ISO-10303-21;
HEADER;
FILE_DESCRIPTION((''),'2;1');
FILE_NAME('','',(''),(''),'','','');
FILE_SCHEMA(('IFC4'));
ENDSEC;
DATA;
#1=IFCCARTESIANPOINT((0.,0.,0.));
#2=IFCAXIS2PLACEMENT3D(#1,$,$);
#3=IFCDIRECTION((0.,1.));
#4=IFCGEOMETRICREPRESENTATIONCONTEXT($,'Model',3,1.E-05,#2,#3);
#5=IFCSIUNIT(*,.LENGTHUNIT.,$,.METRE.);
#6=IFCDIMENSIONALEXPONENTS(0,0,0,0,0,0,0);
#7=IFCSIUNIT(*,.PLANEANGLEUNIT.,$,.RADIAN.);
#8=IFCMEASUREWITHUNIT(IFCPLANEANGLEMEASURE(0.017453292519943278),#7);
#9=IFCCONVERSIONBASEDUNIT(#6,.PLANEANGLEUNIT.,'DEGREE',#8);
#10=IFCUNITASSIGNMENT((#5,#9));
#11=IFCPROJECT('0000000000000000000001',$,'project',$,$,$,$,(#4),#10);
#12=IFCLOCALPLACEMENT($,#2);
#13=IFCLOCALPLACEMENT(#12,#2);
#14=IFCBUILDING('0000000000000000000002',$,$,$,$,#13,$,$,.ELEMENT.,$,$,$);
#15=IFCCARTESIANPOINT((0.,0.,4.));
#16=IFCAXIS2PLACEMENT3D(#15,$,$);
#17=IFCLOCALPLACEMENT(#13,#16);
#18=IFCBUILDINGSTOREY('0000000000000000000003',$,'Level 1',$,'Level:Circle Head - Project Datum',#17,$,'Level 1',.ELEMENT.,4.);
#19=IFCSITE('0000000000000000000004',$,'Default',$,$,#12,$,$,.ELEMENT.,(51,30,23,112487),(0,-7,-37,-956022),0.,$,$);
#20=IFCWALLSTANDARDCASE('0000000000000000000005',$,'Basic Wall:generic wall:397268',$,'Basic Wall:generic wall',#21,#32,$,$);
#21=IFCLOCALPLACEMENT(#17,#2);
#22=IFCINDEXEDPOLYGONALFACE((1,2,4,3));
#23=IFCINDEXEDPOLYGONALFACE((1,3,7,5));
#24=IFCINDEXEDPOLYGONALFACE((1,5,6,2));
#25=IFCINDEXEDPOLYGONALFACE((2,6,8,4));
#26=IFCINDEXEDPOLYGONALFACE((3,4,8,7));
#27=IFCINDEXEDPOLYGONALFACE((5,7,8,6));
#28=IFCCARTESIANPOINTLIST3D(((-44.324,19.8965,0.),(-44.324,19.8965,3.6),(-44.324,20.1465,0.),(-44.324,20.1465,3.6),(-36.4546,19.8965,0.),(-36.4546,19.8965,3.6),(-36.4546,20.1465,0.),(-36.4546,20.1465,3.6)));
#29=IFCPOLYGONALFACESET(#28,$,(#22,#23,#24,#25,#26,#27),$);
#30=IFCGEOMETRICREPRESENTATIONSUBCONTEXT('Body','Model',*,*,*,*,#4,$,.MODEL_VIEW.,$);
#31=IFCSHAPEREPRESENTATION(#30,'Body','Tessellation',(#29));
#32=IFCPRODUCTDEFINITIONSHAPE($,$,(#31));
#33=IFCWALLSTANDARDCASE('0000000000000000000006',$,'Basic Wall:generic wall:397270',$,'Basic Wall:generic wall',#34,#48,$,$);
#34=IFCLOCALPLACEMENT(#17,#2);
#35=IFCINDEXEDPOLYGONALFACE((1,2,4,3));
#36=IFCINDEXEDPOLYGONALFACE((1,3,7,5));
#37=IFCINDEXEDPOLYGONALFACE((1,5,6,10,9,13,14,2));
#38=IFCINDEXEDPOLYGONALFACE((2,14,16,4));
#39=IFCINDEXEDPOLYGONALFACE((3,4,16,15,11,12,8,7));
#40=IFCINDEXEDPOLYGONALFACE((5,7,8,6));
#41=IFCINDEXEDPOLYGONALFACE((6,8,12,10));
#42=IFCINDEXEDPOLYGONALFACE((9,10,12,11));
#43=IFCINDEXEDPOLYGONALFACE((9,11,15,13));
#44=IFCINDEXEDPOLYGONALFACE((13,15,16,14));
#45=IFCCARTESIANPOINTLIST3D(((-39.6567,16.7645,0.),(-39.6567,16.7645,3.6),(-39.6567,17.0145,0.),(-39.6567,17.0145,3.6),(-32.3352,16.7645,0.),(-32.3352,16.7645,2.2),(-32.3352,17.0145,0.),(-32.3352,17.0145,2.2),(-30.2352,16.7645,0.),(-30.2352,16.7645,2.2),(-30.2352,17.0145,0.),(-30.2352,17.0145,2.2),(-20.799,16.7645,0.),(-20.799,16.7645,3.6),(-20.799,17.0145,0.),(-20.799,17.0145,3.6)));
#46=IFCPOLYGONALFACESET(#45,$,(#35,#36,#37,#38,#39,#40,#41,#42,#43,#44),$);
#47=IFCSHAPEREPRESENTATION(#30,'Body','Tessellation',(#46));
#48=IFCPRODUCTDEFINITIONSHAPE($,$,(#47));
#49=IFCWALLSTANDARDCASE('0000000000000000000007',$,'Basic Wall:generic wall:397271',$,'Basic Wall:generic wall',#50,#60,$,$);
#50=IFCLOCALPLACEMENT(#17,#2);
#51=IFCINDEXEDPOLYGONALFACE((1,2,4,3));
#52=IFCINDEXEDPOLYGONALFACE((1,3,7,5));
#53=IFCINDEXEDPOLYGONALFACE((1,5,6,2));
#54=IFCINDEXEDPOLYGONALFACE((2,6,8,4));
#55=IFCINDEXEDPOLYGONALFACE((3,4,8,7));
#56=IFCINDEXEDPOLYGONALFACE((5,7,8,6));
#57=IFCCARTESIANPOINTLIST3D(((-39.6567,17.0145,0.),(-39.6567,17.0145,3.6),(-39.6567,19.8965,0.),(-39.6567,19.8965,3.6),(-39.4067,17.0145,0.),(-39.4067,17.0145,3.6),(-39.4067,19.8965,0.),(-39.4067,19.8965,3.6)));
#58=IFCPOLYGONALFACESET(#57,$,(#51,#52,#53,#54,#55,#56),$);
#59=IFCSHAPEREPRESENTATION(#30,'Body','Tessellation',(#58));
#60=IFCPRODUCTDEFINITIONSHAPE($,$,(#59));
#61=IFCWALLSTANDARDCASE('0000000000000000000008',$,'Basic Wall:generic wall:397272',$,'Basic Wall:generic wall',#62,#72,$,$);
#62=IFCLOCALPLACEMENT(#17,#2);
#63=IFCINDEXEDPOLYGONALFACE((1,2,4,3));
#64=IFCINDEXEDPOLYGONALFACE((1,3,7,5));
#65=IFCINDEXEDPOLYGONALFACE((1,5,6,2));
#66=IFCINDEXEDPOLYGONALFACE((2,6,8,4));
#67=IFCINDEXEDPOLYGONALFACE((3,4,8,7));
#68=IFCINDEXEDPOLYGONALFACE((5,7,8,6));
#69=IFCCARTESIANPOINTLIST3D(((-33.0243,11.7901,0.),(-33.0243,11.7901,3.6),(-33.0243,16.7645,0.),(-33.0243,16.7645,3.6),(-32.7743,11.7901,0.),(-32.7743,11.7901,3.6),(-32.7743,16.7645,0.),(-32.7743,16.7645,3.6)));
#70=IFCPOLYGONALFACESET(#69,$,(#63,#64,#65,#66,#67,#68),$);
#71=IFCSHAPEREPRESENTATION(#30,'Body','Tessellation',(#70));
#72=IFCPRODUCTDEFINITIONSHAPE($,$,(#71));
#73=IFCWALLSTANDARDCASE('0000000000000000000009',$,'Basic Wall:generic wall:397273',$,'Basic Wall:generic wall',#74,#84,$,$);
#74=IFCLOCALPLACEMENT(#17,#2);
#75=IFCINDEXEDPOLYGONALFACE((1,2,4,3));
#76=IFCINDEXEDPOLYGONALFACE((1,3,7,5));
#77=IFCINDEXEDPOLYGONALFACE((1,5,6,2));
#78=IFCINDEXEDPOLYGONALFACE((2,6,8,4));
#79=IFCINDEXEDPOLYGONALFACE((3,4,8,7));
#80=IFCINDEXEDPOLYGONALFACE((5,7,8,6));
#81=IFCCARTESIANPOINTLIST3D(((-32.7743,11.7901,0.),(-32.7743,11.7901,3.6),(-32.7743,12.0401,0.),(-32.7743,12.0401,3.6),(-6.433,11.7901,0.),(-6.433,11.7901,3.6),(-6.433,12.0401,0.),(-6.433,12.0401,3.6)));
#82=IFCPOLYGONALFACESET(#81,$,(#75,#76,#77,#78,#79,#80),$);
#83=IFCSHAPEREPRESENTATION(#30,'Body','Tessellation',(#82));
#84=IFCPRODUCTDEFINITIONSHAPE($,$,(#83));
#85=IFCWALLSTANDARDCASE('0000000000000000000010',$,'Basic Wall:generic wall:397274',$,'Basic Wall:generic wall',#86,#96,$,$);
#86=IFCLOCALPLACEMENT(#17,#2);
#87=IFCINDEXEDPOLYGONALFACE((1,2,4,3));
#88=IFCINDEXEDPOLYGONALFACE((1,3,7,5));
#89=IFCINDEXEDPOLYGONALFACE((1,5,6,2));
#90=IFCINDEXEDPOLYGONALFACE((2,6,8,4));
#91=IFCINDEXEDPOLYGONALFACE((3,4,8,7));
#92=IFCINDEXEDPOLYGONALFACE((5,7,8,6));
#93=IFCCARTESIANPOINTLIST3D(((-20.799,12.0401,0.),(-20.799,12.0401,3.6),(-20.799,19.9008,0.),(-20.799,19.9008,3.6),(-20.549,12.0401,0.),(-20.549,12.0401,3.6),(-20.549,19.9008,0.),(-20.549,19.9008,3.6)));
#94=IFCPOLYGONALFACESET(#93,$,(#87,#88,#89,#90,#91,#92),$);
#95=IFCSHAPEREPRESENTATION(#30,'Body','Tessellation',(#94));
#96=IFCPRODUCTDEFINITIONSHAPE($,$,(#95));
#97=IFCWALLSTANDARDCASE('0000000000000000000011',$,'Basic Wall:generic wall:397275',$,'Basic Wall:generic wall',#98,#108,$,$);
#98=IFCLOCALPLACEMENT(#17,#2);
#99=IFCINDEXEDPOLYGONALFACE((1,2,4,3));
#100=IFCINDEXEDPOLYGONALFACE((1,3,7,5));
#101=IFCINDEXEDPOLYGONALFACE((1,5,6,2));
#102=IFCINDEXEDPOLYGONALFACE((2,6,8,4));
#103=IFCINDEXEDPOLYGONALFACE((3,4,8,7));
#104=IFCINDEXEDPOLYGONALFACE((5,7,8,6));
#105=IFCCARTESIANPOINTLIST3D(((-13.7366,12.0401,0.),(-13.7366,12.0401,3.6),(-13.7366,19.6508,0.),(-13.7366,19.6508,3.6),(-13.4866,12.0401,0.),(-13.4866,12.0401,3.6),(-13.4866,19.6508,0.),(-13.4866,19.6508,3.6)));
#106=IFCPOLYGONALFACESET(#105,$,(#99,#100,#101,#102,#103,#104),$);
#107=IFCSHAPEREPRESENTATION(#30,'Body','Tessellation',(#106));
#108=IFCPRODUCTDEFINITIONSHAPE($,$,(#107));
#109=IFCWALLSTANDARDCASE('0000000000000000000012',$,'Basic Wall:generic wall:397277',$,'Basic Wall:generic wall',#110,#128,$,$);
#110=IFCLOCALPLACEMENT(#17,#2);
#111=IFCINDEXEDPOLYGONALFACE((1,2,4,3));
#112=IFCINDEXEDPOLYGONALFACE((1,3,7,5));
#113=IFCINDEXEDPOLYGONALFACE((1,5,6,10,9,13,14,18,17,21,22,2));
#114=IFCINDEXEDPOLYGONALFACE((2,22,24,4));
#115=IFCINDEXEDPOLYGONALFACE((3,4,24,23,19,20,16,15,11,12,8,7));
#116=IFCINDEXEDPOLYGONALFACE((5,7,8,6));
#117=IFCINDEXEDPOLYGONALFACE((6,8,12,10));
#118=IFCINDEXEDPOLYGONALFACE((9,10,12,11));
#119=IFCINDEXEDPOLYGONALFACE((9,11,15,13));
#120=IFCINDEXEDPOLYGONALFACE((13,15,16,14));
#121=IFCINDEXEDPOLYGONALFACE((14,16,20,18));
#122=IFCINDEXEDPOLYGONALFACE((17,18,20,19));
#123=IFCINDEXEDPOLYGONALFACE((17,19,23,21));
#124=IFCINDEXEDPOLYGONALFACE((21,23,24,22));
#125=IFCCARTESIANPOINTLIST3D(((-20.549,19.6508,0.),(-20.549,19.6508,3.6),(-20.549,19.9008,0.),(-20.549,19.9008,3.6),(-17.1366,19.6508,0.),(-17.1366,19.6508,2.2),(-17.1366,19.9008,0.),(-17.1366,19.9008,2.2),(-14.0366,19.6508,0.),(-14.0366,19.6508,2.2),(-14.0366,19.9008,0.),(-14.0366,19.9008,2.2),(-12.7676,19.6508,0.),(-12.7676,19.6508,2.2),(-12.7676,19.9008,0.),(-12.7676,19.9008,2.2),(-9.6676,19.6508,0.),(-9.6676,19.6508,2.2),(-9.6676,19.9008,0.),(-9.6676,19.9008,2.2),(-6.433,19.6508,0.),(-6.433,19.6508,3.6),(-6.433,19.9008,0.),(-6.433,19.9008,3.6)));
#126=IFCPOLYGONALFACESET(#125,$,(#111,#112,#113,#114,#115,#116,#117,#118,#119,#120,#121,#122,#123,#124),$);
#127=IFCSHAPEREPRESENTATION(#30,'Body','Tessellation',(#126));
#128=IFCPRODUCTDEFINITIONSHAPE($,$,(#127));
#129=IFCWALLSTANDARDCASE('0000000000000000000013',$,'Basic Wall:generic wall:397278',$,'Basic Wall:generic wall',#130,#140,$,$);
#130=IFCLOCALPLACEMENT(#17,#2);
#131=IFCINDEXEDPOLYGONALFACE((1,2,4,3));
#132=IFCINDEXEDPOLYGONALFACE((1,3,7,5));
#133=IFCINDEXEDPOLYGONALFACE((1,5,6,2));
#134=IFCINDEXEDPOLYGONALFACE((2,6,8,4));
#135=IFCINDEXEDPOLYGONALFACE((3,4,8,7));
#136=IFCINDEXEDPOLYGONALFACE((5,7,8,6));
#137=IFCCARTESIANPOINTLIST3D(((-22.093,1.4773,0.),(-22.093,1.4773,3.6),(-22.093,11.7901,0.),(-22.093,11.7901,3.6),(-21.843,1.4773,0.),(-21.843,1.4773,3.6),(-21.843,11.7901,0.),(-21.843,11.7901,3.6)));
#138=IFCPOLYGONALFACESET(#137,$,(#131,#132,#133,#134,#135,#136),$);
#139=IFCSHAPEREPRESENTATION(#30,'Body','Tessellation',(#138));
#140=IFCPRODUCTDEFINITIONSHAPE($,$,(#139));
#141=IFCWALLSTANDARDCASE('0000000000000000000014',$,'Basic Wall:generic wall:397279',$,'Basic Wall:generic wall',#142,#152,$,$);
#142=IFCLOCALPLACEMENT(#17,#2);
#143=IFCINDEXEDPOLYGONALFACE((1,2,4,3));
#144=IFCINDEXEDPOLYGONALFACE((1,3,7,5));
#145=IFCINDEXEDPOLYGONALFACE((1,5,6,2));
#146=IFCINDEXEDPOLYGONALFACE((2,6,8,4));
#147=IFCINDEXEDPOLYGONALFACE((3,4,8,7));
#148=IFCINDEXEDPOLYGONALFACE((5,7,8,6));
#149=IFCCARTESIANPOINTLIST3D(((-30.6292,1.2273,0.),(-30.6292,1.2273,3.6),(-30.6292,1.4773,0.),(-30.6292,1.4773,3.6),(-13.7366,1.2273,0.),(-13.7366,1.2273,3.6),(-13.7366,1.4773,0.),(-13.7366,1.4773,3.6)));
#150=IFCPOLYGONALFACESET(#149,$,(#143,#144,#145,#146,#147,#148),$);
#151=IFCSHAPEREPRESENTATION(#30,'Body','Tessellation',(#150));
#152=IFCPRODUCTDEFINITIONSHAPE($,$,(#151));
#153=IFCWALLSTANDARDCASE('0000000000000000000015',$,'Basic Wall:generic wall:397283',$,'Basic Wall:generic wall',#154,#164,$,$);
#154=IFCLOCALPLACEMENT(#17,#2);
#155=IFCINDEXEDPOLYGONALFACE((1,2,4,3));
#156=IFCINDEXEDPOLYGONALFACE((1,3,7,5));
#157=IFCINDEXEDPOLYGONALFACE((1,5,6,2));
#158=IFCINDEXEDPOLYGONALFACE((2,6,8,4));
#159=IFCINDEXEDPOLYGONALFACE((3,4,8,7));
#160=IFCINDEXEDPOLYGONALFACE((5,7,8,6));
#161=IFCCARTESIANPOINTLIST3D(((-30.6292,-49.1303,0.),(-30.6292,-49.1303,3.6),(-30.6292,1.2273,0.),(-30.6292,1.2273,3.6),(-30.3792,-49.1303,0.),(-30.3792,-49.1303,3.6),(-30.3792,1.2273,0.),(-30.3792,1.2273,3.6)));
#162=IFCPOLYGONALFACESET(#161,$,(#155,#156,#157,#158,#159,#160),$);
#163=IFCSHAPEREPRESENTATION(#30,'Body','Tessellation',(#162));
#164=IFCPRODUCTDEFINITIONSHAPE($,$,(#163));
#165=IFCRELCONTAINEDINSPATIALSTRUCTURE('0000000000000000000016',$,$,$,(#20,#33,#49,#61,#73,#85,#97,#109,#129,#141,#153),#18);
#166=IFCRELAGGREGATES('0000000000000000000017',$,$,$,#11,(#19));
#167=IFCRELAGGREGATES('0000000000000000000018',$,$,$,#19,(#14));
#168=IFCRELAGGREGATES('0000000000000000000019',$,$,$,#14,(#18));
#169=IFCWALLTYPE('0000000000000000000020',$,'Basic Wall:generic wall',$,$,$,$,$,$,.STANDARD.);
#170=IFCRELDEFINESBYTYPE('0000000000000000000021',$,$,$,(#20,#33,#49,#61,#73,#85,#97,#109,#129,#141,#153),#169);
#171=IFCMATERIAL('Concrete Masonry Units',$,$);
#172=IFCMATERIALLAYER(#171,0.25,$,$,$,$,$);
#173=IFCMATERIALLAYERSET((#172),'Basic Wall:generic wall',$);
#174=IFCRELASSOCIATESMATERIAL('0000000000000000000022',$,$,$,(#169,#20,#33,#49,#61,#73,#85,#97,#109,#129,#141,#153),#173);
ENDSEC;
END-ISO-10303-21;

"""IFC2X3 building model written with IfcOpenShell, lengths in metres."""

from ifc_helpers import new_model, entity, si_unit, converted_unit, direction, frame, frame_2d, origin, place, context, subcontext, project, spatial, rectangle, extrude, material, layer, layer_set, layer_usage, type_object, element, save


model = new_model("IFC2X3")

# Units and contexts
model_context = context("Model", 3, precision=1e-05, world=origin(), true_north=direction((0.0, 1.0)))
body_context = subcontext(model_context, "Body", "Model", "MODEL_VIEW")
ifc_project = project(units=[si_unit("LENGTHUNIT", "METRE"), converted_unit("PLANEANGLEUNIT", "DEGREE", entity("IfcPlaneAngleMeasure", 0.017453292519943278), si_unit("PLANEANGLEUNIT", "RADIAN"), dimensions=[0, 0, 0, 0, 0, 0, 0])], contexts=[model_context])

# Site, building, storey
site_placement = place(None, origin())
site = spatial("IfcSite", under=ifc_project, at=site_placement, Name="Default", CompositionType="ELEMENT", RefLatitude=(51, 30, 23, 112487), RefLongitude=(0, -7, -37, -956022), RefElevation=0.0)
building_placement = place(site_placement, origin())
building = spatial("IfcBuilding", under=site, at=building_placement, CompositionType="ELEMENT")
storey_placement = place(building_placement, frame((0.0, 0.0, 4.0)))
storey = spatial("IfcBuildingStorey", under=building, at=storey_placement, Name="Level 1", ObjectType="Level:Circle Head - Project Datum", LongName="Level 1", CompositionType="ELEMENT", Elevation=4.0)

# Wall
ifc_material = material(Name="Concrete Masonry Units")
ifc_layer = layer(ifc_material, 0.25)
ifc_layer_set = layer_set([ifc_layer], Name="Basic Wall:generic wall")
ifc_layer_usage_1 = layer_usage(ifc_layer_set, "AXIS2", "NEGATIVE", 0.125)
wall_type = type_object("IfcWallType", Name="Basic Wall:generic wall", PredefinedType="STANDARD", material=ifc_layer_set)
wall_1_placement = place(storey_placement, frame((-44.324, 20.0215, 0.0)))
element("IfcWallStandardCase", 1, at=wall_1_placement, inside=storey, type_object=wall_type, material=ifc_layer_usage_1, Name="Basic Wall:generic wall:397268", ObjectType="Basic Wall:generic wall", context=body_context, shape_type="SweptSolid", body=[
    extrude(rectangle(XDim=7.8694, YDim=0.25, at=frame_2d((3.9347, 0.0), x_axis=(-1.0, 0.0))), origin(), (0.0, 0.0, 1.0), 3.6),
])

# Wall, opening
ifc_layer_usage_2 = layer_usage(ifc_layer_set, "AXIS2", "NEGATIVE", 0.125)
wall_2_placement = place(storey_placement, frame((-39.6567, 16.8895, 0.0)))
wall_2 = element("IfcWallStandardCase", 2, at=wall_2_placement, inside=storey, type_object=wall_type, material=ifc_layer_usage_2, Name="Basic Wall:generic wall:397270", ObjectType="Basic Wall:generic wall", context=body_context, shape_type="SweptSolid", body=[
    extrude(rectangle(XDim=18.8578, YDim=0.25, at=frame_2d((9.4289, 0.0), x_axis=(-1.0, 0.0))), origin(), (0.0, 0.0, 1.0), 3.6),
])
opening_1_placement = place(wall_2_placement, frame((9.4215, 0.125, 0.0)))
element("IfcOpeningElement", 3, at=opening_1_placement, cuts=wall_2, ObjectType="Opening", context=body_context, shape_type="SweptSolid", body=[
    extrude(rectangle(XDim=2.2, YDim=2.1, at=frame_2d((1.1, 1.05), x_axis=(1.0, 0.0))), frame((0.0, 0.0, 0.0), z_axis=(0.0, -1.0, 0.0), x_axis=(0.0, 0.0, 1.0)), (0.0, 0.0, 1.0), 0.25),
])

# Walls
ifc_layer_usage_3 = layer_usage(ifc_layer_set, "AXIS2", "NEGATIVE", 0.125)
wall_3_placement = place(storey_placement, frame((-39.5317, 19.8965, 0.0), z_axis=(0.0, 0.0, 1.0), x_axis=(0.0, -1.0, 0.0)))
element("IfcWallStandardCase", 4, at=wall_3_placement, inside=storey, type_object=wall_type, material=ifc_layer_usage_3, Name="Basic Wall:generic wall:397271", ObjectType="Basic Wall:generic wall", context=body_context, shape_type="SweptSolid", body=[
    extrude(rectangle(XDim=2.882, YDim=0.25, at=frame_2d((1.441, 0.0), x_axis=(-1.0, 0.0))), origin(), (0.0, 0.0, 1.0), 3.6),
])
ifc_layer_usage_4 = layer_usage(ifc_layer_set, "AXIS2", "NEGATIVE", 0.125)
wall_4_placement = place(storey_placement, frame((-32.8993, 16.7645, 0.0), z_axis=(0.0, 0.0, 1.0), x_axis=(0.0, -1.0, 0.0)))
element("IfcWallStandardCase", 5, at=wall_4_placement, inside=storey, type_object=wall_type, material=ifc_layer_usage_4, Name="Basic Wall:generic wall:397272", ObjectType="Basic Wall:generic wall", context=body_context, shape_type="SweptSolid", body=[
    extrude(rectangle(XDim=4.9744, YDim=0.25, at=frame_2d((2.4872, 0.0), x_axis=(-1.0, 0.0))), origin(), (0.0, 0.0, 1.0), 3.6),
])
ifc_layer_usage_5 = layer_usage(ifc_layer_set, "AXIS2", "NEGATIVE", 0.125)
wall_5_placement = place(storey_placement, frame((-32.7743, 11.9151, 0.0)))
element("IfcWallStandardCase", 6, at=wall_5_placement, inside=storey, type_object=wall_type, material=ifc_layer_usage_5, Name="Basic Wall:generic wall:397273", ObjectType="Basic Wall:generic wall", context=body_context, shape_type="SweptSolid", body=[
    extrude(rectangle(XDim=26.3413, YDim=0.25, at=frame_2d((13.1706, 0.0), x_axis=(-1.0, 0.0))), origin(), (0.0, 0.0, 1.0), 3.6),
])
ifc_layer_usage_6 = layer_usage(ifc_layer_set, "AXIS2", "NEGATIVE", 0.125)
wall_6_placement = place(storey_placement, frame((-20.674, 12.0401, 0.0), z_axis=(0.0, 0.0, 1.0), x_axis=(0.0, 1.0, 0.0)))
element("IfcWallStandardCase", 7, at=wall_6_placement, inside=storey, type_object=wall_type, material=ifc_layer_usage_6, Name="Basic Wall:generic wall:397274", ObjectType="Basic Wall:generic wall", context=body_context, shape_type="SweptSolid", body=[
    extrude(rectangle(XDim=7.8607, YDim=0.25, at=frame_2d((3.9304, 0.0), x_axis=(-1.0, 0.0))), origin(), (0.0, 0.0, 1.0), 3.6),
])
ifc_layer_usage_7 = layer_usage(ifc_layer_set, "AXIS2", "NEGATIVE", 0.125)
wall_7_placement = place(storey_placement, frame((-13.6116, 12.0401, 0.0), z_axis=(0.0, 0.0, 1.0), x_axis=(0.0, 1.0, 0.0)))
element("IfcWallStandardCase", 8, at=wall_7_placement, inside=storey, type_object=wall_type, material=ifc_layer_usage_7, Name="Basic Wall:generic wall:397275", ObjectType="Basic Wall:generic wall", context=body_context, shape_type="SweptSolid", body=[
    extrude(rectangle(XDim=7.6107, YDim=0.25, at=frame_2d((3.8054, 0.0), x_axis=(-1.0, 0.0))), origin(), (0.0, 0.0, 1.0), 3.6),
])

# Wall, openings
ifc_layer_usage_8 = layer_usage(ifc_layer_set, "AXIS2", "NEGATIVE", 0.125)
wall_8_placement = place(storey_placement, frame((-20.549, 19.7758, 0.0)))
wall_8 = element("IfcWallStandardCase", 9, at=wall_8_placement, inside=storey, type_object=wall_type, material=ifc_layer_usage_8, Name="Basic Wall:generic wall:397277", ObjectType="Basic Wall:generic wall", context=body_context, shape_type="SweptSolid", body=[
    extrude(rectangle(XDim=14.116, YDim=0.25, at=frame_2d((7.058, 0.0), x_axis=(-1.0, 0.0))), origin(), (0.0, 0.0, 1.0), 3.6),
])
opening_2_placement = place(wall_8_placement, frame((6.5124, 0.125, 0.0)))
element("IfcOpeningElement", 10, at=opening_2_placement, cuts=wall_8, ObjectType="Opening", context=body_context, shape_type="SweptSolid", body=[
    extrude(rectangle(XDim=2.2, YDim=3.1, at=frame_2d((1.1, 1.55), x_axis=(1.0, 0.0))), frame((0.0, 0.0, 0.0), z_axis=(0.0, -1.0, 0.0), x_axis=(0.0, 0.0, 1.0)), (0.0, 0.0, 1.0), 0.25),
])
opening_3_placement = place(wall_8_placement, frame((10.8814, 0.125, 0.0)))
element("IfcOpeningElement", 11, at=opening_3_placement, cuts=wall_8, ObjectType="Opening", context=body_context, shape_type="SweptSolid", body=[
    extrude(rectangle(XDim=2.2, YDim=3.1, at=frame_2d((1.1, 1.55), x_axis=(1.0, 0.0))), frame((0.0, 0.0, 0.0), z_axis=(0.0, -1.0, 0.0), x_axis=(0.0, 0.0, 1.0)), (0.0, 0.0, 1.0), 0.25),
])

# Walls
ifc_layer_usage_9 = layer_usage(ifc_layer_set, "AXIS2", "NEGATIVE", 0.125)
wall_9_placement = place(storey_placement, frame((-21.968, 11.7901, 0.0), z_axis=(0.0, 0.0, 1.0), x_axis=(0.0, -1.0, 0.0)))
element("IfcWallStandardCase", 12, at=wall_9_placement, inside=storey, type_object=wall_type, material=ifc_layer_usage_9, Name="Basic Wall:generic wall:397278", ObjectType="Basic Wall:generic wall", context=body_context, shape_type="SweptSolid", body=[
    extrude(rectangle(XDim=10.3128, YDim=0.25, at=frame_2d((5.1564, 0.0), x_axis=(-1.0, 0.0))), origin(), (0.0, 0.0, 1.0), 3.6),
])
ifc_layer_usage_10 = layer_usage(ifc_layer_set, "AXIS2", "NEGATIVE", 0.125)
wall_10_placement = place(storey_placement, frame((-30.6292, 1.3523, 0.0)))
element("IfcWallStandardCase", 13, at=wall_10_placement, inside=storey, type_object=wall_type, material=ifc_layer_usage_10, Name="Basic Wall:generic wall:397279", ObjectType="Basic Wall:generic wall", context=body_context, shape_type="SweptSolid", body=[
    extrude(rectangle(XDim=16.8926, YDim=0.25, at=frame_2d((8.4463, 0.0), x_axis=(-1.0, 0.0))), origin(), (0.0, 0.0, 1.0), 3.6),
])
ifc_layer_usage_11 = layer_usage(ifc_layer_set, "AXIS2", "NEGATIVE", 0.125)
wall_11_placement = place(storey_placement, frame((-30.5042, 1.2273, 0.0), z_axis=(0.0, 0.0, 1.0), x_axis=(0.0, -1.0, 0.0)))
element("IfcWallStandardCase", 14, at=wall_11_placement, inside=storey, type_object=wall_type, material=ifc_layer_usage_11, Name="Basic Wall:generic wall:397283", ObjectType="Basic Wall:generic wall", context=body_context, shape_type="SweptSolid", body=[
    extrude(rectangle(XDim=50.3576, YDim=0.25, at=frame_2d((25.1788, 0.0), x_axis=(-1.0, 0.0))), origin(), (0.0, 0.0, 1.0), 3.6),
])

save(model, "model.ifc")
